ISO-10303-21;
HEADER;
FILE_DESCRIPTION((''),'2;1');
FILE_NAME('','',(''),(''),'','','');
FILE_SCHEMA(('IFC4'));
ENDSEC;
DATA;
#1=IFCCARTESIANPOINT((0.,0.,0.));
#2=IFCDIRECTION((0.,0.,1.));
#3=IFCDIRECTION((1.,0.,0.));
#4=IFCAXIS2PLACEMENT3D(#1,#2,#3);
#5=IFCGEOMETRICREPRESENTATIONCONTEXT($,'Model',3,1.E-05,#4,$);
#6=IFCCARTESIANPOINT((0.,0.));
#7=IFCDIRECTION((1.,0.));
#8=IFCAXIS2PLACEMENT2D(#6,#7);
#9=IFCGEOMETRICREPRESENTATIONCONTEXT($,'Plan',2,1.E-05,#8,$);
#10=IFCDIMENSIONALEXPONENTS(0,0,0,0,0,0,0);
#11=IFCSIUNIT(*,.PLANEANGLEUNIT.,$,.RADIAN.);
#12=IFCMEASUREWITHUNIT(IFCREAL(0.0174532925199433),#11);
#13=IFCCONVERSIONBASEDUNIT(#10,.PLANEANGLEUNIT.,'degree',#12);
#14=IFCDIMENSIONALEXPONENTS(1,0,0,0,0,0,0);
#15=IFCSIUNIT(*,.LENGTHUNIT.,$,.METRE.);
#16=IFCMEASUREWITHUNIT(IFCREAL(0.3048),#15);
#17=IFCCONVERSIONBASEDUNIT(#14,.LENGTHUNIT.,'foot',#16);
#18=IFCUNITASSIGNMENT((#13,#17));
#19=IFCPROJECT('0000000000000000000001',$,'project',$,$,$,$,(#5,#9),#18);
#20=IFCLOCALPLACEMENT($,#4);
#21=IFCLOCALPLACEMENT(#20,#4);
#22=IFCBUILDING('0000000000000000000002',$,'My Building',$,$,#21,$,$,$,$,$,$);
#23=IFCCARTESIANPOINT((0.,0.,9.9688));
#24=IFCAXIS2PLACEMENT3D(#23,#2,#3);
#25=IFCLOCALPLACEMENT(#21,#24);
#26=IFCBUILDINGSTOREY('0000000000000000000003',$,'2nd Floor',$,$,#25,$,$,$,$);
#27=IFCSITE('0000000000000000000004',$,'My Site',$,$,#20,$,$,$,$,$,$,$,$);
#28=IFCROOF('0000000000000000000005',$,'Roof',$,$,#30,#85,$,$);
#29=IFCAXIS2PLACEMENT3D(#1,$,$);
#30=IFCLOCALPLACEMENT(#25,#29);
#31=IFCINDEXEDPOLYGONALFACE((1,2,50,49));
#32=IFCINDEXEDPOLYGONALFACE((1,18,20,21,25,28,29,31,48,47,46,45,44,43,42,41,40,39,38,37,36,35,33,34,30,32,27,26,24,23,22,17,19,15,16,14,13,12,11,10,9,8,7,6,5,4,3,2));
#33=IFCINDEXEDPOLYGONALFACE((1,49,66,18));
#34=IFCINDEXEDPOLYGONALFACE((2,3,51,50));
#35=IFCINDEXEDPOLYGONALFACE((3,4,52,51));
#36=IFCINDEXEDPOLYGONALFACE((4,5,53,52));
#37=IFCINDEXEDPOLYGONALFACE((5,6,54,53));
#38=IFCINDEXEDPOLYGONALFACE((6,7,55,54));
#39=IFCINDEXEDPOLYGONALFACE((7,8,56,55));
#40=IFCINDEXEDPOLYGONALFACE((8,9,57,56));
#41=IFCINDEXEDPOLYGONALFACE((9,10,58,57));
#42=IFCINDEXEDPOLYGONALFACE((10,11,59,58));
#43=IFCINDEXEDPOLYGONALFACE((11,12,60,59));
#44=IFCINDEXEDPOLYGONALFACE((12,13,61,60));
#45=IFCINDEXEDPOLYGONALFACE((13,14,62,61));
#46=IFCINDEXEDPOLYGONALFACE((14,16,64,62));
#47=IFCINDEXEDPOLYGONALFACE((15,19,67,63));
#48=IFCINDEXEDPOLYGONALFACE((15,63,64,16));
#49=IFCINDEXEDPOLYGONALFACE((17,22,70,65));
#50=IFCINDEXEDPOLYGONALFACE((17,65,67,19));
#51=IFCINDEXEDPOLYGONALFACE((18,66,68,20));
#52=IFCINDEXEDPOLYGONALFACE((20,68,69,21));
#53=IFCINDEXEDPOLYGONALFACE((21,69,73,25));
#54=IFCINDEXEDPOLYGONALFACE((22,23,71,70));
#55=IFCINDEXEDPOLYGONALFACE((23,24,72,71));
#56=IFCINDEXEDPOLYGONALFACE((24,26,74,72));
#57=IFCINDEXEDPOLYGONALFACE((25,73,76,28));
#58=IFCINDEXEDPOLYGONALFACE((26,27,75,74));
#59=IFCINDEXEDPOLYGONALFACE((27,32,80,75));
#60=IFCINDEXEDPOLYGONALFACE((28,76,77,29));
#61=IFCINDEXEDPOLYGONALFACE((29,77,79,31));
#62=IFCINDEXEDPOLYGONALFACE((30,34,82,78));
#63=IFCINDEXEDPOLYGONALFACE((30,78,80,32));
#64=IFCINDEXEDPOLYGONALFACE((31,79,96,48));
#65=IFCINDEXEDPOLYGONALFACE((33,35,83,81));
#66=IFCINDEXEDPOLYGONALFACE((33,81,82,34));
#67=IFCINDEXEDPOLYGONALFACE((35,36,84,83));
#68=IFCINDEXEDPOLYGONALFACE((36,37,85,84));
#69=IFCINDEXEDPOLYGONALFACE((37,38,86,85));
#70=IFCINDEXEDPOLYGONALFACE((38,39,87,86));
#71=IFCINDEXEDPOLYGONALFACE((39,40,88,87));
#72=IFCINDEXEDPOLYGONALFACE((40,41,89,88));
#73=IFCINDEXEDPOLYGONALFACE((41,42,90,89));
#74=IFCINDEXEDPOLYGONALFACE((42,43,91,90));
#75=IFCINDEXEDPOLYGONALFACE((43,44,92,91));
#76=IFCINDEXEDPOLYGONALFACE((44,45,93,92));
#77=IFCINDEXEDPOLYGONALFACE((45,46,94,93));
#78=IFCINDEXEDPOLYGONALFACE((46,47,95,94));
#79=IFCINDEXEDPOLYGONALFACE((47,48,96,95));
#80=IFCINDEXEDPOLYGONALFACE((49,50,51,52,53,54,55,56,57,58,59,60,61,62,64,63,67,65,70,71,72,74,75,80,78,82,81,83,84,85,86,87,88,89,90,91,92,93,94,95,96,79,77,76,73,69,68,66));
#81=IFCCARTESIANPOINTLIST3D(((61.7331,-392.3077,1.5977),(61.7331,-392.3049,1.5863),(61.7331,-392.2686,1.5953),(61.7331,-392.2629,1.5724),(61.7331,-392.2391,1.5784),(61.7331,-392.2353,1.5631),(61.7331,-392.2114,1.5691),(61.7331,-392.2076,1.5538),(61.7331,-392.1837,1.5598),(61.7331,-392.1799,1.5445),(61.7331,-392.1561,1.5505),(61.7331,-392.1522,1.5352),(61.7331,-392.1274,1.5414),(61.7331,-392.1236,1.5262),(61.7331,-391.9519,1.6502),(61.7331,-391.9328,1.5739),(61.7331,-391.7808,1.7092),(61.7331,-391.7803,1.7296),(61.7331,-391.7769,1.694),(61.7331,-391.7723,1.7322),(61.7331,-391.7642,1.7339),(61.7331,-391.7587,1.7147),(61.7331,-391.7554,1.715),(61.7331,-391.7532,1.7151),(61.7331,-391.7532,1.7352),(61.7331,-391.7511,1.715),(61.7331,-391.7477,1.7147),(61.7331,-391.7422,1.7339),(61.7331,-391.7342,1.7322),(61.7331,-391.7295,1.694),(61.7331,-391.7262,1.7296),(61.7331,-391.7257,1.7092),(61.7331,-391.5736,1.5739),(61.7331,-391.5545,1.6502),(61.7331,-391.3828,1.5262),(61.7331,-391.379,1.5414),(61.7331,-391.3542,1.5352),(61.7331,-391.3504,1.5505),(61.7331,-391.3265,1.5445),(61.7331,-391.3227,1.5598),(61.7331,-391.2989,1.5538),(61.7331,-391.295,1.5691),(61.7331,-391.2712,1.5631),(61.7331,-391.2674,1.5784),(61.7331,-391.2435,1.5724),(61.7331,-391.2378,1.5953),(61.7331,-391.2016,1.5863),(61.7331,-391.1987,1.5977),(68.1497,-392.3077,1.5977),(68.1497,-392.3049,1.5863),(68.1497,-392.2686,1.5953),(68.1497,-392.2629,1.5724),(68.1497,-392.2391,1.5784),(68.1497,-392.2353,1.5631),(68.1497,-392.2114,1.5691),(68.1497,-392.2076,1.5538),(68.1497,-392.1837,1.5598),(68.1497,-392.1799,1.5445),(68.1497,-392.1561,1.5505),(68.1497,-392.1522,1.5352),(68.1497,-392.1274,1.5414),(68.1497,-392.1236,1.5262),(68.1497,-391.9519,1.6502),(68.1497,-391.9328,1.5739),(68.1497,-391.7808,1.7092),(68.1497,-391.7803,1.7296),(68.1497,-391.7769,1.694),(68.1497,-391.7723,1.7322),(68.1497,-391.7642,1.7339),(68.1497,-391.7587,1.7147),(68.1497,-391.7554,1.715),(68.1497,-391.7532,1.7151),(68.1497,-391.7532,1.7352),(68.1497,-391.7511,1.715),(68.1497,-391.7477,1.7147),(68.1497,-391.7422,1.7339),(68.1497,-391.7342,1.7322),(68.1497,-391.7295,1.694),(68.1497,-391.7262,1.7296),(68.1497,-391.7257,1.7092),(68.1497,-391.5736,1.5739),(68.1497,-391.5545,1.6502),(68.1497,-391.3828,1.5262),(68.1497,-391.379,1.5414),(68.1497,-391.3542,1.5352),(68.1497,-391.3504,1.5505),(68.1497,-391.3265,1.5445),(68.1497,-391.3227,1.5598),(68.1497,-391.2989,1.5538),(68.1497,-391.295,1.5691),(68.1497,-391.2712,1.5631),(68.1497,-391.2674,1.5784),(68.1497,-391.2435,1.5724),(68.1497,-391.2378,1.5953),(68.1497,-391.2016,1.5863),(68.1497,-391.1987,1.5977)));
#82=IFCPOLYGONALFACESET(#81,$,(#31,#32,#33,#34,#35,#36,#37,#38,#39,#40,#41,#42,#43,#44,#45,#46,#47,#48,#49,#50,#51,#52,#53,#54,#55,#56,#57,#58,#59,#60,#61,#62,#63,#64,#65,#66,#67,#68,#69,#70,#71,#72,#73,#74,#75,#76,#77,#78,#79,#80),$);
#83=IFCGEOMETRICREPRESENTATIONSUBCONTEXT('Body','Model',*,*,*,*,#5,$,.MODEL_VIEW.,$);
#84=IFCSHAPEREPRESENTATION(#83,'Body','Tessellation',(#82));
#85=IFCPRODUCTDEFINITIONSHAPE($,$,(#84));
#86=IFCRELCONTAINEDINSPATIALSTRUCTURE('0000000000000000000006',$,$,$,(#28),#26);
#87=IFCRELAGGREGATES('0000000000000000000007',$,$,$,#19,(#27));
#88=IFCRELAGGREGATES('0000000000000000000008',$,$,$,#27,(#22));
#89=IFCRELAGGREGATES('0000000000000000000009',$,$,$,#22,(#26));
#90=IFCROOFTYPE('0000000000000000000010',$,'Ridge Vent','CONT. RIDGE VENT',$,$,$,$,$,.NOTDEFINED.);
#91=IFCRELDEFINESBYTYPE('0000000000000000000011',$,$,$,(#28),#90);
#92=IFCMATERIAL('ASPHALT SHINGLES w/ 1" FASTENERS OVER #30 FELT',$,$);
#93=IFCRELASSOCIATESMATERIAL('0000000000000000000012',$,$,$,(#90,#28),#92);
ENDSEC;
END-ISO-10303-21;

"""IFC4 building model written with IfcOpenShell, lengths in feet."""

from ifc_helpers import new_model, entity, si_unit, converted_unit, frame, origin_with_axes, origin_2d_with_axis, place, context, subcontext, project, spatial, indexed_curve, outline, extrude, material, material_profile, profile_set, profile_usage, type_object, element, save


model = new_model("IFC4")

# Units and contexts
model_context = context("Model", 3, precision=1e-05, world=origin_with_axes())
plan_context = context("Plan", 2, precision=1e-05, world=origin_2d_with_axis())
body_context = subcontext(model_context, "Body", "Model", "MODEL_VIEW")
ifc_project = project(units=[converted_unit("PLANEANGLEUNIT", "degree", entity("IfcReal", 0.0174532925199433), si_unit("PLANEANGLEUNIT", "RADIAN"), dimensions=[0, 0, 0, 0, 0, 0, 0]), converted_unit("LENGTHUNIT", "foot", entity("IfcReal", 0.3048), si_unit("LENGTHUNIT", "METRE"), dimensions=[1, 0, 0, 0, 0, 0, 0])], contexts=[model_context, plan_context])

# Site, building, storey
site_placement = place(None, origin_with_axes())
site = spatial("IfcSite", under=ifc_project, at=site_placement, Name="My Site")
building_placement = place(site_placement, origin_with_axes())
building = spatial("IfcBuilding", under=site, at=building_placement, Name="My Building")
storey_placement = place(building_placement, frame((0.0, 0.0, 9.9688), z_axis=(0.0, 0.0, 1.0), x_axis=(1.0, 0.0, 0.0)))
storey = spatial("IfcBuildingStorey", under=building, at=storey_placement, Name="2nd Floor")

# Roof
ifc_material_1 = material(Name="ASPHALT SHINGLES w/ 1\" FASTENERS OVER #30 FELT")
ifc_material_profile_1 = material_profile(ifc_material_1, outline(indexed_curve([(-0.0055, -0.0205), (-0.0022, -0.0202), (0.0, -0.0201), (0.0022, -0.0202), (0.0055, -0.0205), (0.0275, -0.0259), (0.0237, -0.0412), (0.1987, -0.085), (0.1796, -0.1613), (0.3704, -0.209), (0.3742, -0.1937), (0.399, -0.1999), (0.4028, -0.1847), (0.4267, -0.1906), (0.4305, -0.1754), (0.4544, -0.1813), (0.4582, -0.1661), (0.482, -0.172), (0.4859, -0.1568), (0.5097, -0.1627), (0.5154, -0.1398), (0.5517, -0.1489), (0.5545, -0.1374), (0.027, -0.0055), (0.0191, -0.003), (0.011, -0.0013), (0.0, 0.0), (-0.011, -0.0013), (-0.019, -0.003), (-0.027, -0.0055), (-0.5545, -0.1374), (-0.5517, -0.1489), (-0.5154, -0.1398), (-0.5097, -0.1627), (-0.4859, -0.1568), (-0.482, -0.172), (-0.4582, -0.1661), (-0.4544, -0.1813), (-0.4305, -0.1754), (-0.4267, -0.1906), (-0.4028, -0.1847), (-0.399, -0.1999), (-0.3742, -0.1937), (-0.3704, -0.209), (-0.1796, -0.1613), (-0.1987, -0.085), (-0.0237, -0.0412), (-0.0275, -0.0259), (-0.0055, -0.0205)])))
ifc_profile_set_1 = profile_set([ifc_material_profile_1])
ifc_profile_usage_1 = profile_usage(ifc_profile_set_1, cardinal=5)
roof_type = type_object("IfcRoofType", Name="Ridge Vent", Description="CONT. RIDGE VENT", PredefinedType="NOTDEFINED", material=ifc_profile_set_1)
roof_placement = place(storey_placement, frame((68.1497, -391.7532, 1.7352), z_axis=(-1.0, 0.0, 0.0), x_axis=(0.0, -1.0, 0.0)))
element("IfcRoof", 1, at=roof_placement, inside=storey, type_object=roof_type, material=ifc_profile_usage_1, Name="Roof", context=body_context, shape_type="SweptSolid", body=[
    extrude(outline(indexed_curve([(-0.0055, -0.0205), (-0.0022, -0.0202), (0.0, -0.0201), (0.0022, -0.0202), (0.0055, -0.0205), (0.0275, -0.0259), (0.0237, -0.0412), (0.1987, -0.085), (0.1796, -0.1613), (0.3704, -0.209), (0.3742, -0.1937), (0.399, -0.1999), (0.4028, -0.1847), (0.4267, -0.1906), (0.4305, -0.1754), (0.4544, -0.1813), (0.4582, -0.1661), (0.482, -0.172), (0.4859, -0.1568), (0.5097, -0.1627), (0.5154, -0.1398), (0.5517, -0.1489), (0.5545, -0.1374), (0.027, -0.0055), (0.0191, -0.003), (0.011, -0.0013), (0.0, 0.0), (-0.011, -0.0013), (-0.019, -0.003), (-0.027, -0.0055), (-0.5545, -0.1374), (-0.5517, -0.1489), (-0.5154, -0.1398), (-0.5097, -0.1627), (-0.4859, -0.1568), (-0.482, -0.172), (-0.4582, -0.1661), (-0.4544, -0.1813), (-0.4305, -0.1754), (-0.4267, -0.1906), (-0.4028, -0.1847), (-0.399, -0.1999), (-0.3742, -0.1937), (-0.3704, -0.209), (-0.1796, -0.1613), (-0.1987, -0.085), (-0.0237, -0.0412), (-0.0275, -0.0259), (-0.0055, -0.0205)])), origin_with_axes(), (0.0, 0.0, 1.0), 6.4167),
])

save(model, "model.ifc")
